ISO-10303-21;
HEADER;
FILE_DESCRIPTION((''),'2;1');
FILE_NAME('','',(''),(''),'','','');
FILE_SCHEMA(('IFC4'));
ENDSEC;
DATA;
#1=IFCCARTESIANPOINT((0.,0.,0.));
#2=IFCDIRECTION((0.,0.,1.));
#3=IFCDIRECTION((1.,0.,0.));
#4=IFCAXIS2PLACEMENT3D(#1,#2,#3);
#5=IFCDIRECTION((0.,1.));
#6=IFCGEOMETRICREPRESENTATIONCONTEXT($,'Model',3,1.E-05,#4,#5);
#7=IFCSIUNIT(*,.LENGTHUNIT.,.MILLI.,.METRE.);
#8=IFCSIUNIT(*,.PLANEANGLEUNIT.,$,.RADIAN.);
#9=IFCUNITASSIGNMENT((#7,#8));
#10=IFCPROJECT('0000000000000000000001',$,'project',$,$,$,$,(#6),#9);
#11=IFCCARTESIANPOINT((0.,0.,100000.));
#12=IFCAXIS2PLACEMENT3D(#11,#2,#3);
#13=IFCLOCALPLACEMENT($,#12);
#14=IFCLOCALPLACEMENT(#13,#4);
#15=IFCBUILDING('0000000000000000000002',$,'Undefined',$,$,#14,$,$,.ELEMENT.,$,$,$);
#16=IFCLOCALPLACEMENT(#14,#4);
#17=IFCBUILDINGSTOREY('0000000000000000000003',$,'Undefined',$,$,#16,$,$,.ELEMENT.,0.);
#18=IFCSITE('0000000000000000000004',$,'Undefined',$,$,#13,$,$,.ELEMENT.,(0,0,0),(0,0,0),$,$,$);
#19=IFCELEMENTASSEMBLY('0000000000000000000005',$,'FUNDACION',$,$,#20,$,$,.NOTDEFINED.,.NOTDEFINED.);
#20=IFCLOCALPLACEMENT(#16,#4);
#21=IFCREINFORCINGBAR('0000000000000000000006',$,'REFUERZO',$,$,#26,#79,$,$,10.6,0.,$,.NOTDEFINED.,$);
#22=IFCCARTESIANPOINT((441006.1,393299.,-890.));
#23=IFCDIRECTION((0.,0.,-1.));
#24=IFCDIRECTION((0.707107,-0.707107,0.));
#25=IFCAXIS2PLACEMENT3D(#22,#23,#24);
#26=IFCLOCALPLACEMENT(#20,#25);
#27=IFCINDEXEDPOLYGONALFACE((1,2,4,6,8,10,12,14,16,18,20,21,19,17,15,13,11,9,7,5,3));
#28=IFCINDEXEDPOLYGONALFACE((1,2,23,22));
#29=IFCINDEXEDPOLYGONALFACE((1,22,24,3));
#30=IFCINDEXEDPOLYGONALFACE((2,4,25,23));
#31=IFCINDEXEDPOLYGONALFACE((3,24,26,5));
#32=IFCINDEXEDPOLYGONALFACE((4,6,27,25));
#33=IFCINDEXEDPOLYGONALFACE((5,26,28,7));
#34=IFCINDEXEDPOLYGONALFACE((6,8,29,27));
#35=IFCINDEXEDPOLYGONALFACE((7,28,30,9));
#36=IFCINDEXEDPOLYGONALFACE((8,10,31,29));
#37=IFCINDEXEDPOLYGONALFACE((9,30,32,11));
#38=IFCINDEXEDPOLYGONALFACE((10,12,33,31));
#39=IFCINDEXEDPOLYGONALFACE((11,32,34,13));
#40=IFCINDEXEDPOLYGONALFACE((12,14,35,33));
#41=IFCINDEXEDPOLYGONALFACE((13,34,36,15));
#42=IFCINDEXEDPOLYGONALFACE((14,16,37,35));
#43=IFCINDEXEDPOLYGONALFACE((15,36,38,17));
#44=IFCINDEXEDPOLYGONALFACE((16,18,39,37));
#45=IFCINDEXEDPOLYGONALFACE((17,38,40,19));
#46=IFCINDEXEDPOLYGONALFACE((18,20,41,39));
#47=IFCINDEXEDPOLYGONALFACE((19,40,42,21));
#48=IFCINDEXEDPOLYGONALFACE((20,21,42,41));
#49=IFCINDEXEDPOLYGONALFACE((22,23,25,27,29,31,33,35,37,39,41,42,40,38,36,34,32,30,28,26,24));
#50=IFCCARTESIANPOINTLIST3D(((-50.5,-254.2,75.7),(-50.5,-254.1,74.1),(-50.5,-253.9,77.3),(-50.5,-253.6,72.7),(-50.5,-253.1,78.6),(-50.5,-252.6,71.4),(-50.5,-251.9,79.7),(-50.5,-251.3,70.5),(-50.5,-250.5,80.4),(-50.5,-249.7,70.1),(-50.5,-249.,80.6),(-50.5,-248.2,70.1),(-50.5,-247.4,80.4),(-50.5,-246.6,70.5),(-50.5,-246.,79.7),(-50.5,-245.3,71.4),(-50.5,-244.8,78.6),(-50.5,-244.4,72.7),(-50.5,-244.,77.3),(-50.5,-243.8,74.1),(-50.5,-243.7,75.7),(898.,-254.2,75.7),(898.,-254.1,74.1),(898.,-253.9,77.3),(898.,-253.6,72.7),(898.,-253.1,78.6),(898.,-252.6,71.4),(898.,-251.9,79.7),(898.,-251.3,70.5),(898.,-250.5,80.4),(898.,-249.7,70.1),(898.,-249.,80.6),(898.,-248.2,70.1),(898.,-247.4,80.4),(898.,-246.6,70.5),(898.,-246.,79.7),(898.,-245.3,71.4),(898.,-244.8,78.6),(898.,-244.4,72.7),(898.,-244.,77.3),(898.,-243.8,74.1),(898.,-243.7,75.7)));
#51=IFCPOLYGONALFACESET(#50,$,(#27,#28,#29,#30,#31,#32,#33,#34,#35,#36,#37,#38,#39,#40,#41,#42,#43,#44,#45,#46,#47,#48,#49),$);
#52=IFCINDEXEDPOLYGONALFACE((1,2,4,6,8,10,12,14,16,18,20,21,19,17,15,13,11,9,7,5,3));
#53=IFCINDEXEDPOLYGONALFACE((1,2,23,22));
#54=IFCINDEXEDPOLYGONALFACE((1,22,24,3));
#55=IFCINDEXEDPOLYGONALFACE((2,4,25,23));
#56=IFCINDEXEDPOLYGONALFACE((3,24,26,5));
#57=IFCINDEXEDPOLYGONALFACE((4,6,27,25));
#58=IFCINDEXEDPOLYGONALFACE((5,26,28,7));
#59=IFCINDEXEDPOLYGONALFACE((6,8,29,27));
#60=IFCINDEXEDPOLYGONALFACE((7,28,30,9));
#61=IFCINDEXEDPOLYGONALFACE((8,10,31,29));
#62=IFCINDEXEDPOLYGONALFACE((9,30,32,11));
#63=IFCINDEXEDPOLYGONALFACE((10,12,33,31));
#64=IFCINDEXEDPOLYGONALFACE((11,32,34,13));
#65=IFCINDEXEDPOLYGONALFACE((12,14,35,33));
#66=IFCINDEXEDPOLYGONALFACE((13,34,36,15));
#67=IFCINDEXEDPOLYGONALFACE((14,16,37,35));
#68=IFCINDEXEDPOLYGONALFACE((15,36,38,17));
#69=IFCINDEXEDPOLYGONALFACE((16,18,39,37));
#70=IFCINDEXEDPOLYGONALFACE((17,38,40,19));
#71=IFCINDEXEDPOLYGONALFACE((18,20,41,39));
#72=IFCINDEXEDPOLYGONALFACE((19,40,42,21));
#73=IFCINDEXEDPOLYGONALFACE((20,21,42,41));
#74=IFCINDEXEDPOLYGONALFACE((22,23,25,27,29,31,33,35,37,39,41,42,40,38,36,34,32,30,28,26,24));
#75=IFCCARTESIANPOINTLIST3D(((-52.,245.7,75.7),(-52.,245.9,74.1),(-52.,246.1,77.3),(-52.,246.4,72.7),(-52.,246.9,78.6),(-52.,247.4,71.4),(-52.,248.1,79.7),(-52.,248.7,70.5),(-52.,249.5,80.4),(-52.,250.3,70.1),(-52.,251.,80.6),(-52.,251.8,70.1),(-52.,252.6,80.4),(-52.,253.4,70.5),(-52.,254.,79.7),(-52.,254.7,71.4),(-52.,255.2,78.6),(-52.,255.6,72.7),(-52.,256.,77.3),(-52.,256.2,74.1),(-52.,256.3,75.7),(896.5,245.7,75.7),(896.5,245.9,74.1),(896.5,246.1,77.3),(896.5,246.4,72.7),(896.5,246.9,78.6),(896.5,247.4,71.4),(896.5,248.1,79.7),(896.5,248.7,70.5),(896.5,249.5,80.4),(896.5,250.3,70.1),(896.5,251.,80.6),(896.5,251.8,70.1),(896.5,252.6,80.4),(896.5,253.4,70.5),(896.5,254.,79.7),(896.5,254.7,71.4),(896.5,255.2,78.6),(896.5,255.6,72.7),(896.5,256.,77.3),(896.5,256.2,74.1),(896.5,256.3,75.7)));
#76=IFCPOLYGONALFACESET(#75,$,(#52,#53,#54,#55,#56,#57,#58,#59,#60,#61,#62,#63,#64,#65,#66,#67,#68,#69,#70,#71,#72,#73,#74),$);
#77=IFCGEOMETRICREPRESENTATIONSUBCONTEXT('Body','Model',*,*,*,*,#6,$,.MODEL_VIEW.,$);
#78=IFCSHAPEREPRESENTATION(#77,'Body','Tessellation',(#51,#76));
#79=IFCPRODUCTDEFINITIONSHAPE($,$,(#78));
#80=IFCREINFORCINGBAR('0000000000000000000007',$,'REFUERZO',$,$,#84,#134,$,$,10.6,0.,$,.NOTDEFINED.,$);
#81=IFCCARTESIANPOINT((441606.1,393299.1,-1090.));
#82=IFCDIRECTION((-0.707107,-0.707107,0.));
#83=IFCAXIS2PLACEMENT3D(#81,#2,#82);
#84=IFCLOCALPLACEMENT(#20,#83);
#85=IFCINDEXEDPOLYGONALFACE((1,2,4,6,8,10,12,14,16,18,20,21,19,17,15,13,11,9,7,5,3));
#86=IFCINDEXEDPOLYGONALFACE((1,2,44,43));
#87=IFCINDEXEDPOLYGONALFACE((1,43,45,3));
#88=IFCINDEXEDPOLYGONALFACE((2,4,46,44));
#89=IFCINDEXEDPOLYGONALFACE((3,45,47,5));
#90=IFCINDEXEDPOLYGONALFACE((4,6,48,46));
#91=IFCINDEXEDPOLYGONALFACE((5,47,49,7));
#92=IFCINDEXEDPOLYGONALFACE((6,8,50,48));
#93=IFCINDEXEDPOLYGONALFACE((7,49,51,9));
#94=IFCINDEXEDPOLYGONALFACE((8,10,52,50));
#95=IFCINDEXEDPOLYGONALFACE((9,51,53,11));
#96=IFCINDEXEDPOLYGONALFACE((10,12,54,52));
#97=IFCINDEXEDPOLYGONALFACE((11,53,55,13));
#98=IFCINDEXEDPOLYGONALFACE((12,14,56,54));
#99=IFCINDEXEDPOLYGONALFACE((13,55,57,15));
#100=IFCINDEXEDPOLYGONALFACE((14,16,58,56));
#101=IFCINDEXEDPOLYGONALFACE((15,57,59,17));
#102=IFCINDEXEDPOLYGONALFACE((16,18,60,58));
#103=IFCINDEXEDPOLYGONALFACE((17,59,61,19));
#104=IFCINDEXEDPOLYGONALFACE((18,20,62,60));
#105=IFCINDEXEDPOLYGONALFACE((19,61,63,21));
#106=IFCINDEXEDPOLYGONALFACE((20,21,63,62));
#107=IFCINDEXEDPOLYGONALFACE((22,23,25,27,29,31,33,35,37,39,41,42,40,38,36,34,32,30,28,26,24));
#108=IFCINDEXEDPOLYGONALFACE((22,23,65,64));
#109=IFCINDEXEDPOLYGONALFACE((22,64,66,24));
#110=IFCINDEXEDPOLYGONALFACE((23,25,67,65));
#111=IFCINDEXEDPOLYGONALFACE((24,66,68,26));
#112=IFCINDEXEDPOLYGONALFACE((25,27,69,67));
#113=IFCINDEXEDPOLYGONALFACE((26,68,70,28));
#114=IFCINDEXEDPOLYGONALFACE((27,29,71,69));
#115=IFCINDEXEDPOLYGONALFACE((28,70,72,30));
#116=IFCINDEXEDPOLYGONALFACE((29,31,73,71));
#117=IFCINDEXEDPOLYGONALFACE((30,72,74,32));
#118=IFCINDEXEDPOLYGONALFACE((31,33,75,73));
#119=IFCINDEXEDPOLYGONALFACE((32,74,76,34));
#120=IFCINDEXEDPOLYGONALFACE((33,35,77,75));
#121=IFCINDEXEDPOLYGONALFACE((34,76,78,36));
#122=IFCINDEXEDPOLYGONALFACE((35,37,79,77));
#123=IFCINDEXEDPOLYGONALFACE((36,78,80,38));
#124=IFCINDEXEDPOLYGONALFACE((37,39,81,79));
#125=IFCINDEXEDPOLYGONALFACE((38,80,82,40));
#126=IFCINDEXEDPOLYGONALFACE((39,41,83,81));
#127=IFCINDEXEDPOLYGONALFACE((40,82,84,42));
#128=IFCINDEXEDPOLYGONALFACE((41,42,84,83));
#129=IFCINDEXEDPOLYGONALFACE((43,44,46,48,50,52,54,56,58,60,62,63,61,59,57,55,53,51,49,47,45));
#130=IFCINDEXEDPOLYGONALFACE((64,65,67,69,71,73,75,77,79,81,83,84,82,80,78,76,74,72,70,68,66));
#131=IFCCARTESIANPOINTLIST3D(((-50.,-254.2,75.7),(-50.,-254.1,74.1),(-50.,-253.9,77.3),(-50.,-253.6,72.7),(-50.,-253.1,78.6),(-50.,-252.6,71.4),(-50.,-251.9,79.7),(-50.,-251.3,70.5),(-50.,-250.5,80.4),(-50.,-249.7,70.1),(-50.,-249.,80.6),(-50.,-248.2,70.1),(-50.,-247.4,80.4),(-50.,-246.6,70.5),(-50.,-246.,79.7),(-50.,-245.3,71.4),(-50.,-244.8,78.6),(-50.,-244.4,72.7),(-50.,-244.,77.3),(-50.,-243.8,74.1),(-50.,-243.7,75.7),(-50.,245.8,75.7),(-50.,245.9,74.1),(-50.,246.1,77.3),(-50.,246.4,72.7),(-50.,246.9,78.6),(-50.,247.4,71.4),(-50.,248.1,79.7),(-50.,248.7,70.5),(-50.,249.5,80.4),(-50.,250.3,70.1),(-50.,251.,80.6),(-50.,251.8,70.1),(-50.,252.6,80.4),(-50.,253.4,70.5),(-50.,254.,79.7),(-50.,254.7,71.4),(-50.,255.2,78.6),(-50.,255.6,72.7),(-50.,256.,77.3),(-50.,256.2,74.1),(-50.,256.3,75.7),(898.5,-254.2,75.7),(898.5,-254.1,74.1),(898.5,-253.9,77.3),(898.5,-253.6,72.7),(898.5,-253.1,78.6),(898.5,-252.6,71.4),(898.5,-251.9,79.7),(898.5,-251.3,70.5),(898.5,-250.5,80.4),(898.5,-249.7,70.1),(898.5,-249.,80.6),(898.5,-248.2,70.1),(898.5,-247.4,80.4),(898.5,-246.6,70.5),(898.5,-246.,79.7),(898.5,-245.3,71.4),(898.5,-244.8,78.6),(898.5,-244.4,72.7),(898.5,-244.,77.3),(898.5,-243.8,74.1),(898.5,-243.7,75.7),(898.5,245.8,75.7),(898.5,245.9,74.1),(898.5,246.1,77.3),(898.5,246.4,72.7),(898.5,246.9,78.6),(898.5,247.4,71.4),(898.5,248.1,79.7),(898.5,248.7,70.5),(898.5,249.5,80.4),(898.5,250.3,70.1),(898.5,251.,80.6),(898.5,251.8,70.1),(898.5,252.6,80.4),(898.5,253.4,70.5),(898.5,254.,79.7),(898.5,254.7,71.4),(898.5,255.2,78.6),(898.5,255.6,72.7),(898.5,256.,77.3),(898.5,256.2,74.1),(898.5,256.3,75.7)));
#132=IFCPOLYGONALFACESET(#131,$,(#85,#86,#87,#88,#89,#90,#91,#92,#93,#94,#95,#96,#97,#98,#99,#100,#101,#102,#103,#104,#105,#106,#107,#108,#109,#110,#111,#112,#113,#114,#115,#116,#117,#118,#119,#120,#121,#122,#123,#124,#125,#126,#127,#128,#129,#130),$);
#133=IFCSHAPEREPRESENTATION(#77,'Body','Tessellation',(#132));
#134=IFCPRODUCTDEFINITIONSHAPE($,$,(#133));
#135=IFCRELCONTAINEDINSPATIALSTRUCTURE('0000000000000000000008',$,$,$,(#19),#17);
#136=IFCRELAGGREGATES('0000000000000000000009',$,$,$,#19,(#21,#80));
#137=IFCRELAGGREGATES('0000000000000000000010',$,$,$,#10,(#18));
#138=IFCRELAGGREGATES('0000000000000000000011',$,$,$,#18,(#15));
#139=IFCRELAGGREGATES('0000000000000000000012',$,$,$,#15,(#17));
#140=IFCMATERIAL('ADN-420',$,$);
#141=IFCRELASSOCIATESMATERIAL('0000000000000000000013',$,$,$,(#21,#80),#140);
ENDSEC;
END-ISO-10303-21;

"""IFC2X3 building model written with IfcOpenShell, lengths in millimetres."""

from ifc_helpers import new_model, entity, si_unit, direction, frame, origin_with_axes, place, context, subcontext, project, spatial, source, transform, mapped, material, element, aggregate, save


model = new_model("IFC2X3")

# Units and contexts
model_context = context("Model", 3, precision=1e-05, world=origin_with_axes(), true_north=direction((0.0, 1.0)))
body_context = subcontext(model_context, "Body", "Model", "MODEL_VIEW")
ifc_project = project(units=[si_unit("LENGTHUNIT", "METRE", prefix="MILLI"), si_unit("PLANEANGLEUNIT", "RADIAN")], contexts=[model_context])

# Site, building, storey
site_placement = place(None, frame((0.0, 0.0, 100000.0), z_axis=(0.0, 0.0, 1.0), x_axis=(1.0, 0.0, 0.0)))
site = spatial("IfcSite", under=ifc_project, at=site_placement, Name="Undefined", CompositionType="ELEMENT", RefLatitude=(0, 0, 0), RefLongitude=(0, 0, 0))
building_placement = place(site_placement, origin_with_axes())
building = spatial("IfcBuilding", under=site, at=building_placement, Name="Undefined", CompositionType="ELEMENT")
storey_placement = place(building_placement, origin_with_axes())
storey = spatial("IfcBuildingStorey", under=building, at=storey_placement, Name="Undefined", CompositionType="ELEMENT", Elevation=0.0)

# Element assembly, reinforcing bars
assembly_1_placement = place(storey_placement, origin_with_axes())
assembly_1 = element("IfcElementAssembly", 1, at=assembly_1_placement, inside=storey, Name="FUNDACION", AssemblyPlace="NOTDEFINED", PredefinedType="NOTDEFINED")
ifc_material_1 = material(Name="ADN-420")
shared_shape_1 = source(origin_with_axes(), body_context, "Body", "AdvancedSweptSolid", [
    entity("IfcSweptDiskSolid", entity("IfcTrimmedCurve", entity("IfcLine", entity("IfcCartesianPoint", [0.0, 0.0, 0.0]), entity("IfcVector", entity("IfcDirection", [1.0, 0.0, 0.0]), 1.0)), [entity("IfcParameterValue", 0.0)], [entity("IfcParameterValue", 948.528137)], True, "PARAMETER"), 5.3, None, 0.0, 948.5),
])
shared_shape_2 = source(origin_with_axes(), body_context, "Body", "AdvancedSweptSolid", [
    entity("IfcSweptDiskSolid", entity("IfcTrimmedCurve", entity("IfcLine", entity("IfcCartesianPoint", [0.0, 0.0, 0.0]), entity("IfcVector", entity("IfcDirection", [1.0, 0.0, 0.0]), 1.0)), [entity("IfcParameterValue", 0.0)], [entity("IfcParameterValue", 948.528137)], True, "PARAMETER"), 5.3, None, 0.0, 948.5),
])
reinforcing_bar_1_placement = place(assembly_1_placement, frame((441006.1, 393299.0, -890.0), z_axis=(0.0, 0.0, -1.0), x_axis=(0.707107, -0.707107, 0.0)))
reinforcing_bar_1 = element("IfcReinforcingBar", 2, at=reinforcing_bar_1_placement, material=ifc_material_1, Name="REFUERZO", BarRole="NOTDEFINED", CrossSectionArea=0.0, NominalDiameter=10.6, context=body_context, shape_type="MappedRepresentation", body=[
    mapped(shared_shape_1, transform((-50.5, -249.0, 75.3))),
    mapped(shared_shape_2, transform((-52.0, 251.0, 75.3))),
])
shared_shape_3 = source(origin_with_axes(), body_context, "Body", "AdvancedSweptSolid", [
    entity("IfcSweptDiskSolid", entity("IfcTrimmedCurve", entity("IfcLine", entity("IfcCartesianPoint", [0.0, 0.0, 0.0]), entity("IfcVector", entity("IfcDirection", [1.0, 0.0, 0.0]), 1.0)), [entity("IfcParameterValue", 0.0)], [entity("IfcParameterValue", 948.528137)], True, "PARAMETER"), 5.3, None, 0.0, 948.5),
])
shared_shape_4 = source(origin_with_axes(), body_context, "Body", "AdvancedSweptSolid", [
    entity("IfcSweptDiskSolid", entity("IfcTrimmedCurve", entity("IfcLine", entity("IfcCartesianPoint", [0.0, 0.0, 0.0]), entity("IfcVector", entity("IfcDirection", [1.0, 0.0, 0.0]), 1.0)), [entity("IfcParameterValue", 0.0)], [entity("IfcParameterValue", 948.528137)], True, "PARAMETER"), 5.3, None, 0.0, 948.5),
])
reinforcing_bar_2_placement = place(assembly_1_placement, frame((441606.1, 393299.1, -1090.0), z_axis=(0.0, 0.0, 1.0), x_axis=(-0.707107, -0.707107, 0.0)))
reinforcing_bar_2 = element("IfcReinforcingBar", 3, at=reinforcing_bar_2_placement, material=ifc_material_1, Name="REFUERZO", BarRole="NOTDEFINED", CrossSectionArea=0.0, NominalDiameter=10.6, context=body_context, shape_type="MappedRepresentation", body=[
    mapped(shared_shape_3, transform((-50.0, -249.0, 75.3))),
    mapped(shared_shape_4, transform((-50.0, 251.0, 75.3))),
])
aggregate(assembly_1, [reinforcing_bar_1, reinforcing_bar_2])

save(model, "model.ifc")
